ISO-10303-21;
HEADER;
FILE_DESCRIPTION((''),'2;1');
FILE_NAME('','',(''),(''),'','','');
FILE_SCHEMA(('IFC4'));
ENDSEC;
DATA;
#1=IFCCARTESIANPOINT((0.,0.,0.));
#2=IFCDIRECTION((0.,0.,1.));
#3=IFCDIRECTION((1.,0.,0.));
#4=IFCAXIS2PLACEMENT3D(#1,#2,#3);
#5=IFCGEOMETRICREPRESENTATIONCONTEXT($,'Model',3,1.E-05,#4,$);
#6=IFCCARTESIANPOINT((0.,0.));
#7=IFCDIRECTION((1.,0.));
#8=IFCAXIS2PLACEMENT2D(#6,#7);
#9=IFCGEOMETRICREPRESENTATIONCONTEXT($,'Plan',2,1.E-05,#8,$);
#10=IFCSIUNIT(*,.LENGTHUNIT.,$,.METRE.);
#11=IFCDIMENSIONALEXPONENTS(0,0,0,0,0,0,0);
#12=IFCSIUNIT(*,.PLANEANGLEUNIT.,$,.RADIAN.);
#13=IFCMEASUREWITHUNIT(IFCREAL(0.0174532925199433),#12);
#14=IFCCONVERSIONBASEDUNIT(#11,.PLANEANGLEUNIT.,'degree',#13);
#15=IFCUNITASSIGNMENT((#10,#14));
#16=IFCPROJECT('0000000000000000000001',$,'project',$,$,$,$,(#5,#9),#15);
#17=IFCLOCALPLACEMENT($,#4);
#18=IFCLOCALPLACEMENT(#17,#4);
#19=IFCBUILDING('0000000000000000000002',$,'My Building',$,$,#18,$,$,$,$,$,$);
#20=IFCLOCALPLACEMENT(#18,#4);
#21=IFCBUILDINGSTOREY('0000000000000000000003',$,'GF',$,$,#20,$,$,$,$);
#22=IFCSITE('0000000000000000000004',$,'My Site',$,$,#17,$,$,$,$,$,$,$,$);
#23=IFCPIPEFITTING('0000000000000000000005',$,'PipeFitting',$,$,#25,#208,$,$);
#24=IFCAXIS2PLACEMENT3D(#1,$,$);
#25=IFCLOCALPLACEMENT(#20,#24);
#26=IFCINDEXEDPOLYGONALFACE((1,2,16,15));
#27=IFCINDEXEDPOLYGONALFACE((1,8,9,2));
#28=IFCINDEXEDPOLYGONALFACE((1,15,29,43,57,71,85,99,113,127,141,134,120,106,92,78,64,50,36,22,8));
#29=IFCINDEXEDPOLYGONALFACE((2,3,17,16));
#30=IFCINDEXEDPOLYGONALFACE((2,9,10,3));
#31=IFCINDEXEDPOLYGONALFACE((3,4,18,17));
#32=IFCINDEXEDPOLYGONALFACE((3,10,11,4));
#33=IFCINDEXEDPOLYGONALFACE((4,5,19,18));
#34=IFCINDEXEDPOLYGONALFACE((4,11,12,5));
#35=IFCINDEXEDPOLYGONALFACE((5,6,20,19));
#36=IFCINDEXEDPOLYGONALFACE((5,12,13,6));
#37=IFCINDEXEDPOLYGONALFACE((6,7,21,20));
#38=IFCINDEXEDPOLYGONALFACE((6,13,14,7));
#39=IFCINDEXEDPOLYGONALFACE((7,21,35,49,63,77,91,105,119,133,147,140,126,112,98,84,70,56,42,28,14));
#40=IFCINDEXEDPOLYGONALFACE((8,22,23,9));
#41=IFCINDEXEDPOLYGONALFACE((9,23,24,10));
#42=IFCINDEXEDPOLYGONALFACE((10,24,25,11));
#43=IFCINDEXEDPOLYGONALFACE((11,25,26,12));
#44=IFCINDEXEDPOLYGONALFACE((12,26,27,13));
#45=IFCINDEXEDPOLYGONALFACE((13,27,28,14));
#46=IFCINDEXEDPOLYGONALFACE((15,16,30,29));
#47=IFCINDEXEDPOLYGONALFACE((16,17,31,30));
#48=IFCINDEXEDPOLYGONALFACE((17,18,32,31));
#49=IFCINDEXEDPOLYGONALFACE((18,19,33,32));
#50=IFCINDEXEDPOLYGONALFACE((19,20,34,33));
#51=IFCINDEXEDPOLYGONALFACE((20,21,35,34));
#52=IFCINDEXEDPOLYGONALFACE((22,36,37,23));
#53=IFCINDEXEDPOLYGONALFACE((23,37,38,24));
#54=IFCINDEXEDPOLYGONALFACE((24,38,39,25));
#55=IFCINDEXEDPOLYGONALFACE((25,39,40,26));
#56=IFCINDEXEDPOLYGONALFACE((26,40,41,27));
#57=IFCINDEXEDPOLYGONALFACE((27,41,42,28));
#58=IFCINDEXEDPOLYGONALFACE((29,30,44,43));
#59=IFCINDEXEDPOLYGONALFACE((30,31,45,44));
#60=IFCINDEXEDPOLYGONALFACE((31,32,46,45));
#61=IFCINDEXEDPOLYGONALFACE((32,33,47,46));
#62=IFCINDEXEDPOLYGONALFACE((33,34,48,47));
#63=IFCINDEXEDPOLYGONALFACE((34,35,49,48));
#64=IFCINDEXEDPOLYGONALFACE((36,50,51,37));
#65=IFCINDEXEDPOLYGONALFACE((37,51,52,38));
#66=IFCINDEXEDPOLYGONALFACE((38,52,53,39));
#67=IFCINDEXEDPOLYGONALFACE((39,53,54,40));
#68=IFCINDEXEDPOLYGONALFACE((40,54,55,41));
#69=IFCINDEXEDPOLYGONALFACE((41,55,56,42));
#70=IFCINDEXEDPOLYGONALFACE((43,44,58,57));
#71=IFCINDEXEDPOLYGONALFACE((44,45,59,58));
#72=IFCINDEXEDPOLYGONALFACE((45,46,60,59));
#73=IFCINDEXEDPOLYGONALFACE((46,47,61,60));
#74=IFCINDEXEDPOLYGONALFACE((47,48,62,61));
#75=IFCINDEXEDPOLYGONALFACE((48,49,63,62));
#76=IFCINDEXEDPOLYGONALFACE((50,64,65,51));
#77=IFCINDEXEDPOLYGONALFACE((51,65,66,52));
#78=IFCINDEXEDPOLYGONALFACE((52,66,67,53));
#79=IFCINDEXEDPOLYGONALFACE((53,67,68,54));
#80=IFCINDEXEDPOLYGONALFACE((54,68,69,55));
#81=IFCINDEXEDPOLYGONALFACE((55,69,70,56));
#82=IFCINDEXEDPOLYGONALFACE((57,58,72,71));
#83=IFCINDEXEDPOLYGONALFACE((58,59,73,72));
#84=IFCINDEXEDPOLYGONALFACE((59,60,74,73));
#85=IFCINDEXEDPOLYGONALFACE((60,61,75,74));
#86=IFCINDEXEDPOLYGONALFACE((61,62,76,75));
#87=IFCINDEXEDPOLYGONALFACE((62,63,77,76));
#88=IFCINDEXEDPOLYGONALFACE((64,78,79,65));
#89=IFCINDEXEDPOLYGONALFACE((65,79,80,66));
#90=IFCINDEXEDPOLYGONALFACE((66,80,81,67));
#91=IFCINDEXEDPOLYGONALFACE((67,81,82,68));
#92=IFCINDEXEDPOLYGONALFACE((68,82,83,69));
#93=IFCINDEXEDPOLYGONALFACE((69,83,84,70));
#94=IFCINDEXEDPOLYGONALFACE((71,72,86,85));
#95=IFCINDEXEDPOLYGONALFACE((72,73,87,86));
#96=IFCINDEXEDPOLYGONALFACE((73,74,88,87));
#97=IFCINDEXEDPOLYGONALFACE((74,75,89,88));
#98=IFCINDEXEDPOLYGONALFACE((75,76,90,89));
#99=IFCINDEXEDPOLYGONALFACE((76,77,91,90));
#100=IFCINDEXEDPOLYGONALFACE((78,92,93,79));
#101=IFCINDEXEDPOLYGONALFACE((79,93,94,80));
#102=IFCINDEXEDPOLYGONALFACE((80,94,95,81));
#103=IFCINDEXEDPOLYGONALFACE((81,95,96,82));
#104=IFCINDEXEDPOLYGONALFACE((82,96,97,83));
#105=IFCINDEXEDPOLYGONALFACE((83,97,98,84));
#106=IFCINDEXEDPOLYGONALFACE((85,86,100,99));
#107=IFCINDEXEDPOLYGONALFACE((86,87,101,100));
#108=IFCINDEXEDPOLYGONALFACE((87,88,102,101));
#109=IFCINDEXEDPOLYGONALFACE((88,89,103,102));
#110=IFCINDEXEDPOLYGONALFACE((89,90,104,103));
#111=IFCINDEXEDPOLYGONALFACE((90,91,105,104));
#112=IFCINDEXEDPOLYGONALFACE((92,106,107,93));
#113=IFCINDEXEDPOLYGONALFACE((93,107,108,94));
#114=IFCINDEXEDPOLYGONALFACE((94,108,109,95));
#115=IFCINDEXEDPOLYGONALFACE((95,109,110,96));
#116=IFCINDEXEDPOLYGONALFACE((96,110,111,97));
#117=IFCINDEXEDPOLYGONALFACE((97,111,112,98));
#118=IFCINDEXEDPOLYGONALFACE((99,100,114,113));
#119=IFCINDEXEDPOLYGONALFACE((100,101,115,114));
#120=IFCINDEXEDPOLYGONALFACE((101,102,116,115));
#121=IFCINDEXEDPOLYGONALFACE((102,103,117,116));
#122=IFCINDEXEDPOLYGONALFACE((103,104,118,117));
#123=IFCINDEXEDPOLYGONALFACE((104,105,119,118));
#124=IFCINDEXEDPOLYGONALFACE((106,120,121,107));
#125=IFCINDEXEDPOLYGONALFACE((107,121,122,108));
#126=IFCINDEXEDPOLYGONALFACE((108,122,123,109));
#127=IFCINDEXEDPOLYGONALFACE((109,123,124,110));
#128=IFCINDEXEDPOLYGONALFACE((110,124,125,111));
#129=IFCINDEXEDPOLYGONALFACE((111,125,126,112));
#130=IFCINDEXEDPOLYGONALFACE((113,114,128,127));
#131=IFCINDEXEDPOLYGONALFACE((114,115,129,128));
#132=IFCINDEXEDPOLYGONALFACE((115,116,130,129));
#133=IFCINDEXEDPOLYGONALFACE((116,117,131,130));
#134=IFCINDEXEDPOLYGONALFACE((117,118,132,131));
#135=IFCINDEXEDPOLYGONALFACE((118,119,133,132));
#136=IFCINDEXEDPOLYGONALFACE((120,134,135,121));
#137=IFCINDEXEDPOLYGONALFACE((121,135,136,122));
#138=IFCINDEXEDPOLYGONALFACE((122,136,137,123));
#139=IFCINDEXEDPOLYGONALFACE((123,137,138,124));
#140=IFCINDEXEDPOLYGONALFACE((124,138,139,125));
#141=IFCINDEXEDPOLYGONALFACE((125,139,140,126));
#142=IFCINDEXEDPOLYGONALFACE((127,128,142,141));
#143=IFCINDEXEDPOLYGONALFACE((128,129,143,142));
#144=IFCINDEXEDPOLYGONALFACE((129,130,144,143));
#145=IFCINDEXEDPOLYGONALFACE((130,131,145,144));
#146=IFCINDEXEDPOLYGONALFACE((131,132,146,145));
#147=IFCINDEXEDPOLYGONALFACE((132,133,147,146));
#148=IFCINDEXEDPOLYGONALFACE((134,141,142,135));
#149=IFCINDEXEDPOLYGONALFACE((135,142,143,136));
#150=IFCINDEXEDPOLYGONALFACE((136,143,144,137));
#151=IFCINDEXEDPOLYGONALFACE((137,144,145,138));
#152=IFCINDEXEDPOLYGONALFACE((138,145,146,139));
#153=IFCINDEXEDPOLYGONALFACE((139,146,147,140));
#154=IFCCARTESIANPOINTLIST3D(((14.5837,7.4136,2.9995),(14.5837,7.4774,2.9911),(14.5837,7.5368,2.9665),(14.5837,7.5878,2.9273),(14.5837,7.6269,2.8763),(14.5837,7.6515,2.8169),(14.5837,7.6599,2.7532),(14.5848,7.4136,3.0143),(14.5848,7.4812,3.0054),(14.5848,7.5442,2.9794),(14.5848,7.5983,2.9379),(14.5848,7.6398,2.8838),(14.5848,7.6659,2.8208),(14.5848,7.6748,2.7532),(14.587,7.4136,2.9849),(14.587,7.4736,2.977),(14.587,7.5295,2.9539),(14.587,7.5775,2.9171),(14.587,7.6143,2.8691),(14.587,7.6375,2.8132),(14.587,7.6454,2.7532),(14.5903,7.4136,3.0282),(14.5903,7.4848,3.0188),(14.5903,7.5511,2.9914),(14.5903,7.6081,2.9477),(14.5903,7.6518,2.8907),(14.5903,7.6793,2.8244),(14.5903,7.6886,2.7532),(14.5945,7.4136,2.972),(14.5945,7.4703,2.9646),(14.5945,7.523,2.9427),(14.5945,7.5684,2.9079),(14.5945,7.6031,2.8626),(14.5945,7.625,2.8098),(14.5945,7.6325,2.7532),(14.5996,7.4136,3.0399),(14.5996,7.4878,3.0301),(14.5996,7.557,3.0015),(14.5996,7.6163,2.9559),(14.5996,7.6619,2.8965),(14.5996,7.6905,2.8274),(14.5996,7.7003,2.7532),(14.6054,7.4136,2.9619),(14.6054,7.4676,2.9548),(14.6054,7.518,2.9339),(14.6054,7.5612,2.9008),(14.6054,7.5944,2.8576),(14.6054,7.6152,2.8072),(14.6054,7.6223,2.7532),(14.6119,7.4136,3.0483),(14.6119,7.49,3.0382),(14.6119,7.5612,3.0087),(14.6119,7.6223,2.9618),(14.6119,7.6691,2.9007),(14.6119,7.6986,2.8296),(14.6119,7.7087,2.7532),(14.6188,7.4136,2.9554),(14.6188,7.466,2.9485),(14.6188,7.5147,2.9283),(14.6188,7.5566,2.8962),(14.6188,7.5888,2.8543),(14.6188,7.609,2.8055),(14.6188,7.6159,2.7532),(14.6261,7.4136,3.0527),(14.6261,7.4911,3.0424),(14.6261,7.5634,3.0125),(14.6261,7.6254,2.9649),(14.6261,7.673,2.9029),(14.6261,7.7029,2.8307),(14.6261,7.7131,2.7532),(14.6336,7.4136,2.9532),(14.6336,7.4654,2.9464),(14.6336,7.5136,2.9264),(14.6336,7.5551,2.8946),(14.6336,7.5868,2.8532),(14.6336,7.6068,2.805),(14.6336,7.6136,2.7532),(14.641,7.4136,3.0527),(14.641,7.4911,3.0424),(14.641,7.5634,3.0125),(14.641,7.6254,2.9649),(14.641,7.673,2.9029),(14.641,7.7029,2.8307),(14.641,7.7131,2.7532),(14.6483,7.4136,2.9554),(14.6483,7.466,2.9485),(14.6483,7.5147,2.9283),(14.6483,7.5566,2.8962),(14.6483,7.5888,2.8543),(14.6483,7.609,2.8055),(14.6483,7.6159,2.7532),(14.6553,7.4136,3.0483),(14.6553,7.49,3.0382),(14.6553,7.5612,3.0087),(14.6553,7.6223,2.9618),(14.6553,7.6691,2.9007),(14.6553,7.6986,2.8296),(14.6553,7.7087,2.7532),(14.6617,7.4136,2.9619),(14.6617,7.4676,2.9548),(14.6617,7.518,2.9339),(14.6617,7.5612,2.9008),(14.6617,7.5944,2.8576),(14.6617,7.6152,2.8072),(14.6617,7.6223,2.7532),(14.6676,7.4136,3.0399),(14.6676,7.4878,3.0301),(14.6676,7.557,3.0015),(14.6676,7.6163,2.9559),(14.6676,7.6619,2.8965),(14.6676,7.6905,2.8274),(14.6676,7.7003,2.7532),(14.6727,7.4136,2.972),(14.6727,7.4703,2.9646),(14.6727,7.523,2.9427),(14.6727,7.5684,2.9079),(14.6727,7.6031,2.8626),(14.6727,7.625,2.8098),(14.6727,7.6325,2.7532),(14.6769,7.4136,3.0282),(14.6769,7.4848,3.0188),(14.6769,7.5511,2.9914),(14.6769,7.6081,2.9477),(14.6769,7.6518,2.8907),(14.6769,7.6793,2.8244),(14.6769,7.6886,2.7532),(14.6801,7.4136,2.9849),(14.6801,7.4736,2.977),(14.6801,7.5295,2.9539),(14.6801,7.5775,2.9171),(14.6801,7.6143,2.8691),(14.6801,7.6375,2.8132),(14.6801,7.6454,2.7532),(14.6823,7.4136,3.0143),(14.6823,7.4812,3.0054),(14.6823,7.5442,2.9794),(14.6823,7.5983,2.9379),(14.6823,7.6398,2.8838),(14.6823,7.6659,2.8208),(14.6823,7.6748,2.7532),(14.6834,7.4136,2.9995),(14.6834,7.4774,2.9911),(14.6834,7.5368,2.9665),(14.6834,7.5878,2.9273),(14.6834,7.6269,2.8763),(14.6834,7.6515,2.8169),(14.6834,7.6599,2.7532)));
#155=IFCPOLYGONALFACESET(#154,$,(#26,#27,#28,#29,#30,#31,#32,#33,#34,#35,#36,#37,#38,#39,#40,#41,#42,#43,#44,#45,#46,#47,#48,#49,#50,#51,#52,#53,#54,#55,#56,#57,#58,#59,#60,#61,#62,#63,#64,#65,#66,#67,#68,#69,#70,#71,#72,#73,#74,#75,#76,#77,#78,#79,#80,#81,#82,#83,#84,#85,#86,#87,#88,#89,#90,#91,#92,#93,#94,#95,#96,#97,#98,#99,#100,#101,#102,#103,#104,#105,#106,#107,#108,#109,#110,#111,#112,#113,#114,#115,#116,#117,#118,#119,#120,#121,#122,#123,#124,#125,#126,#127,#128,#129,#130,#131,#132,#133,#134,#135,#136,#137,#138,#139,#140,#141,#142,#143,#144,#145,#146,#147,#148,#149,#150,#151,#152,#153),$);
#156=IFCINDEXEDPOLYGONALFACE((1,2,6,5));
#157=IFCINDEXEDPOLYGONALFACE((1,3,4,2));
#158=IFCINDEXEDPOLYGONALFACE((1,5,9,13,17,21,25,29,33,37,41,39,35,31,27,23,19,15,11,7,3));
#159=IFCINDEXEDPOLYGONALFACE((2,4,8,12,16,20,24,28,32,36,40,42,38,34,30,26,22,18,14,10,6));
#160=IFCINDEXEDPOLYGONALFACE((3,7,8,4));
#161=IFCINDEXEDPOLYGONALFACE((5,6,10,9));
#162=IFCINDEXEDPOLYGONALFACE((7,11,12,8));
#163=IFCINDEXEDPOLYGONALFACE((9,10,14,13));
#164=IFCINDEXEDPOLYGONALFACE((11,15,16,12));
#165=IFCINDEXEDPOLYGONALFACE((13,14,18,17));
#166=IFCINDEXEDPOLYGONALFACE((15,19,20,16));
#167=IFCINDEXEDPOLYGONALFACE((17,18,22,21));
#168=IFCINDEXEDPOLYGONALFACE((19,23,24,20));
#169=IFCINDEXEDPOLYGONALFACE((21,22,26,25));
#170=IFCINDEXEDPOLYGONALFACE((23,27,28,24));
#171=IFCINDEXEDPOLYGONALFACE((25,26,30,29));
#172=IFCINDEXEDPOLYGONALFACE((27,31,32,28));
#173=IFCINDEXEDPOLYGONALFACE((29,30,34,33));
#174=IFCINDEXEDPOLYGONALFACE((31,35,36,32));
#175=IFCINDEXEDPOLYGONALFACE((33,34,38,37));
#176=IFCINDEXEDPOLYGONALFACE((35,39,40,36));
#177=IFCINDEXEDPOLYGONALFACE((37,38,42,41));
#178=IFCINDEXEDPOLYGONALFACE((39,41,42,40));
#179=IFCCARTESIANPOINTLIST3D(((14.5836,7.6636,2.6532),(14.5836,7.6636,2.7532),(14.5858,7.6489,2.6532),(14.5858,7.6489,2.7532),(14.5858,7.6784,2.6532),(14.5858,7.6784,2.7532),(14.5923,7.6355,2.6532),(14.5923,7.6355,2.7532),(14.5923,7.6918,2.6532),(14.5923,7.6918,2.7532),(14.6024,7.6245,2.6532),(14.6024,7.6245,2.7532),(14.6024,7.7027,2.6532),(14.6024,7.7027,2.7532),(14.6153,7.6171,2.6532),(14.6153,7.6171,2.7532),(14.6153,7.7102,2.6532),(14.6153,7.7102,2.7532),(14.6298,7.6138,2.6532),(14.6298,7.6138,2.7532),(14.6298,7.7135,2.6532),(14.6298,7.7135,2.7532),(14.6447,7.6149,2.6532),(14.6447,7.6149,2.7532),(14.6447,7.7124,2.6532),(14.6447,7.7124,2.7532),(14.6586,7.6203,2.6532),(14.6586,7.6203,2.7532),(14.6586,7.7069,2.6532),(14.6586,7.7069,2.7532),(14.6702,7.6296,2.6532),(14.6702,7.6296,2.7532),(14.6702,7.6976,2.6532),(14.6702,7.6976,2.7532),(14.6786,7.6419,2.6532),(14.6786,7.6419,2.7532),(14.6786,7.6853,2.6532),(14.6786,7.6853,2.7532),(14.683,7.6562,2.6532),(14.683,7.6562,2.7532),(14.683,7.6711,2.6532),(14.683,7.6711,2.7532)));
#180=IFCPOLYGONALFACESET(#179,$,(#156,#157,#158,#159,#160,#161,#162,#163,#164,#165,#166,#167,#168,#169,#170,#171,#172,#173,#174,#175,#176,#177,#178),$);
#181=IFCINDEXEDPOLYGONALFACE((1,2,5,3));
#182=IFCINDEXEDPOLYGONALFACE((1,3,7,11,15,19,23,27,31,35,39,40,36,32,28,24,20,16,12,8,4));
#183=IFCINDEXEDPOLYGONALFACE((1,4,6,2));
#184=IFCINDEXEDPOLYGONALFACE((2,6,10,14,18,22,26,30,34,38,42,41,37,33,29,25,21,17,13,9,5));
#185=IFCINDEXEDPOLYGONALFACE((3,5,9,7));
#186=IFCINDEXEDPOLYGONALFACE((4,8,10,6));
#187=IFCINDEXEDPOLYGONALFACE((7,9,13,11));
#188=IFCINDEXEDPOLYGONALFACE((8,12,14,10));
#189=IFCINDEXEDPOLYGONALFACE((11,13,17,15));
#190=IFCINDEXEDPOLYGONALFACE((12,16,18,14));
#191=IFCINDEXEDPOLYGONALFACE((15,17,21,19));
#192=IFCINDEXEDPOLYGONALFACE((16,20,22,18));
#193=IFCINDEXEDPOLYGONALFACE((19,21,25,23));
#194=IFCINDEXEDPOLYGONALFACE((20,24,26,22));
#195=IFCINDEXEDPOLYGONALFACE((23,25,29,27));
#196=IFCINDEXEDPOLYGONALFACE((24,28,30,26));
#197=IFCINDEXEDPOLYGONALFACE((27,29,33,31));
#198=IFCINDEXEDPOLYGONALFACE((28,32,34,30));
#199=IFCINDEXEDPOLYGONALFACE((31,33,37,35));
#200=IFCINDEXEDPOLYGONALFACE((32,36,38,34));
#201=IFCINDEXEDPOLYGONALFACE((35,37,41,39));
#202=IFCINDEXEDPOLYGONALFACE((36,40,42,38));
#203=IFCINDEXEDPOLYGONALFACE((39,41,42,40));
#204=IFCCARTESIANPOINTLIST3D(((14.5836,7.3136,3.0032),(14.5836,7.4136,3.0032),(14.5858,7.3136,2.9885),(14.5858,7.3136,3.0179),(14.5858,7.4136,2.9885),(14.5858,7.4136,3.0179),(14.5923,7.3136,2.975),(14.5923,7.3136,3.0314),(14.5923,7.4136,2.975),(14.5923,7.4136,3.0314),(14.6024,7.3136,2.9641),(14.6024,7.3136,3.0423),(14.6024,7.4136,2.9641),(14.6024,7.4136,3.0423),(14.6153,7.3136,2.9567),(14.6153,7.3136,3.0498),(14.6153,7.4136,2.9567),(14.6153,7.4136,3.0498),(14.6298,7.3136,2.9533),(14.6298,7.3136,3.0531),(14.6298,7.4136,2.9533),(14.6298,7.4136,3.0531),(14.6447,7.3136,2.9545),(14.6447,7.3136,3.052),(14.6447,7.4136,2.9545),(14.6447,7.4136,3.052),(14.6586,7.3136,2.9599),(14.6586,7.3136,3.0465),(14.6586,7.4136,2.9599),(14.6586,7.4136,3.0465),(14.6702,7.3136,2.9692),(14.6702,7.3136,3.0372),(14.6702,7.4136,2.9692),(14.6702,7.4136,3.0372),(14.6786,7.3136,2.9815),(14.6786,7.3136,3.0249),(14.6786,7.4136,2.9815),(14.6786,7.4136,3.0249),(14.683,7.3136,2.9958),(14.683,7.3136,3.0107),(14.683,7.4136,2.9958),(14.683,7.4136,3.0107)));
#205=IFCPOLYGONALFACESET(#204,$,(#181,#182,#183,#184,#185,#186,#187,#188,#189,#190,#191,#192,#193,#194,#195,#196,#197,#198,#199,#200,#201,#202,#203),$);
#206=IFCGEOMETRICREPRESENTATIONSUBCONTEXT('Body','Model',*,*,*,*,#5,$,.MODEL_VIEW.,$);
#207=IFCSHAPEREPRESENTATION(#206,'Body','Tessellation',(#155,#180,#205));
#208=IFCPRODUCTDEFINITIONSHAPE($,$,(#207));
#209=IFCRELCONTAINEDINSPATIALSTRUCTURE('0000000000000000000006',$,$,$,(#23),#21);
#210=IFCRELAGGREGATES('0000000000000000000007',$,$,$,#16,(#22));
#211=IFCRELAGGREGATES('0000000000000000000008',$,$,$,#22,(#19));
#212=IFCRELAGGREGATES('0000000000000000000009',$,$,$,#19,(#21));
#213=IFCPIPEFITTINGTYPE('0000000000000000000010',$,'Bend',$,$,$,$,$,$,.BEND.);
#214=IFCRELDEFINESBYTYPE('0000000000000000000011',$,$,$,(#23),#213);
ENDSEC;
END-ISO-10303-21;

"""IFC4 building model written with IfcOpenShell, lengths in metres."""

from ifc_helpers import new_model, entity, si_unit, converted_unit, frame, origin_with_axes, origin_2d_with_axis, place, context, subcontext, project, spatial, circle, extrude, source, transform, mapped, type_object, type_shapes, element, save


model = new_model("IFC4")

# Units and contexts
model_context = context("Model", 3, precision=1e-05, world=origin_with_axes())
plan_context = context("Plan", 2, precision=1e-05, world=origin_2d_with_axis())
body_context_1 = subcontext(model_context, "Body", "Model", "MODEL_VIEW")
ifc_project = project(units=[si_unit("LENGTHUNIT", "METRE"), converted_unit("PLANEANGLEUNIT", "degree", entity("IfcReal", 0.0174532925199433), si_unit("PLANEANGLEUNIT", "RADIAN"), dimensions=[0, 0, 0, 0, 0, 0, 0])], contexts=[model_context, plan_context])

# Site, building, storey
site_placement = place(None, origin_with_axes())
site = spatial("IfcSite", under=ifc_project, at=site_placement, Name="My Site")
building_placement = place(site_placement, origin_with_axes())
building = spatial("IfcBuilding", under=site, at=building_placement, Name="My Building")
storey_placement = place(building_placement, origin_with_axes())
storey = spatial("IfcBuildingStorey", under=building, at=storey_placement, Name="GF")

# Pipe fitting
pipe_fitting_type = type_object("IfcPipeFittingType", Name="Bend", PredefinedType="BEND")
shared_shape_1 = source(origin_with_axes(), body_context_1, "Body", "SolidModel", [
    entity("IfcSweptDiskSolid", entity("IfcIndexedPolyCurve", entity("IfcCartesianPointList3D", [[0.0, 0.0, -0.1], [0.0, -0.0732, -0.2768], [0.0, -0.25, -0.35]]), [entity("IfcArcIndex", [1, 2, 3])]), 0.05),
    extrude(circle(Radius=0.05), origin_with_axes(), (0.0, 0.0, -1.0), 0.1),
    extrude(circle(Radius=0.05), frame((0.0, -0.25, -0.35), z_axis=(0.0, -1.0, 0.0), x_axis=(1.0, 0.0, 0.0)), (0.0, 0.0, 1.0), 0.1),
])
type_shapes(pipe_fitting_type, [shared_shape_1])
for number, where, z_axis, x_axis, name in (
    (1, (14.6336, 7.6636, 2.6532), (0.0, 0.0, -1.0), (-1.0, 0.0, 0.0), "PipeFitting"),
):
    element("IfcPipeFitting", number, at=place(storey_placement, frame(where, z_axis=z_axis, x_axis=x_axis)), inside=storey, type_object=pipe_fitting_type, Name=name, context=body_context_1, shape_type="MappedRepresentation", body=[
        mapped(shared_shape_1, transform((0.0, 0.0, 0.0), x_axis=(1.0, 0.0, 0.0), y_axis=(0.0, 1.0, 0.0), z_axis=(0.0, 0.0, 1.0), scale=1.0)),
    ])

save(model, "model.ifc")
